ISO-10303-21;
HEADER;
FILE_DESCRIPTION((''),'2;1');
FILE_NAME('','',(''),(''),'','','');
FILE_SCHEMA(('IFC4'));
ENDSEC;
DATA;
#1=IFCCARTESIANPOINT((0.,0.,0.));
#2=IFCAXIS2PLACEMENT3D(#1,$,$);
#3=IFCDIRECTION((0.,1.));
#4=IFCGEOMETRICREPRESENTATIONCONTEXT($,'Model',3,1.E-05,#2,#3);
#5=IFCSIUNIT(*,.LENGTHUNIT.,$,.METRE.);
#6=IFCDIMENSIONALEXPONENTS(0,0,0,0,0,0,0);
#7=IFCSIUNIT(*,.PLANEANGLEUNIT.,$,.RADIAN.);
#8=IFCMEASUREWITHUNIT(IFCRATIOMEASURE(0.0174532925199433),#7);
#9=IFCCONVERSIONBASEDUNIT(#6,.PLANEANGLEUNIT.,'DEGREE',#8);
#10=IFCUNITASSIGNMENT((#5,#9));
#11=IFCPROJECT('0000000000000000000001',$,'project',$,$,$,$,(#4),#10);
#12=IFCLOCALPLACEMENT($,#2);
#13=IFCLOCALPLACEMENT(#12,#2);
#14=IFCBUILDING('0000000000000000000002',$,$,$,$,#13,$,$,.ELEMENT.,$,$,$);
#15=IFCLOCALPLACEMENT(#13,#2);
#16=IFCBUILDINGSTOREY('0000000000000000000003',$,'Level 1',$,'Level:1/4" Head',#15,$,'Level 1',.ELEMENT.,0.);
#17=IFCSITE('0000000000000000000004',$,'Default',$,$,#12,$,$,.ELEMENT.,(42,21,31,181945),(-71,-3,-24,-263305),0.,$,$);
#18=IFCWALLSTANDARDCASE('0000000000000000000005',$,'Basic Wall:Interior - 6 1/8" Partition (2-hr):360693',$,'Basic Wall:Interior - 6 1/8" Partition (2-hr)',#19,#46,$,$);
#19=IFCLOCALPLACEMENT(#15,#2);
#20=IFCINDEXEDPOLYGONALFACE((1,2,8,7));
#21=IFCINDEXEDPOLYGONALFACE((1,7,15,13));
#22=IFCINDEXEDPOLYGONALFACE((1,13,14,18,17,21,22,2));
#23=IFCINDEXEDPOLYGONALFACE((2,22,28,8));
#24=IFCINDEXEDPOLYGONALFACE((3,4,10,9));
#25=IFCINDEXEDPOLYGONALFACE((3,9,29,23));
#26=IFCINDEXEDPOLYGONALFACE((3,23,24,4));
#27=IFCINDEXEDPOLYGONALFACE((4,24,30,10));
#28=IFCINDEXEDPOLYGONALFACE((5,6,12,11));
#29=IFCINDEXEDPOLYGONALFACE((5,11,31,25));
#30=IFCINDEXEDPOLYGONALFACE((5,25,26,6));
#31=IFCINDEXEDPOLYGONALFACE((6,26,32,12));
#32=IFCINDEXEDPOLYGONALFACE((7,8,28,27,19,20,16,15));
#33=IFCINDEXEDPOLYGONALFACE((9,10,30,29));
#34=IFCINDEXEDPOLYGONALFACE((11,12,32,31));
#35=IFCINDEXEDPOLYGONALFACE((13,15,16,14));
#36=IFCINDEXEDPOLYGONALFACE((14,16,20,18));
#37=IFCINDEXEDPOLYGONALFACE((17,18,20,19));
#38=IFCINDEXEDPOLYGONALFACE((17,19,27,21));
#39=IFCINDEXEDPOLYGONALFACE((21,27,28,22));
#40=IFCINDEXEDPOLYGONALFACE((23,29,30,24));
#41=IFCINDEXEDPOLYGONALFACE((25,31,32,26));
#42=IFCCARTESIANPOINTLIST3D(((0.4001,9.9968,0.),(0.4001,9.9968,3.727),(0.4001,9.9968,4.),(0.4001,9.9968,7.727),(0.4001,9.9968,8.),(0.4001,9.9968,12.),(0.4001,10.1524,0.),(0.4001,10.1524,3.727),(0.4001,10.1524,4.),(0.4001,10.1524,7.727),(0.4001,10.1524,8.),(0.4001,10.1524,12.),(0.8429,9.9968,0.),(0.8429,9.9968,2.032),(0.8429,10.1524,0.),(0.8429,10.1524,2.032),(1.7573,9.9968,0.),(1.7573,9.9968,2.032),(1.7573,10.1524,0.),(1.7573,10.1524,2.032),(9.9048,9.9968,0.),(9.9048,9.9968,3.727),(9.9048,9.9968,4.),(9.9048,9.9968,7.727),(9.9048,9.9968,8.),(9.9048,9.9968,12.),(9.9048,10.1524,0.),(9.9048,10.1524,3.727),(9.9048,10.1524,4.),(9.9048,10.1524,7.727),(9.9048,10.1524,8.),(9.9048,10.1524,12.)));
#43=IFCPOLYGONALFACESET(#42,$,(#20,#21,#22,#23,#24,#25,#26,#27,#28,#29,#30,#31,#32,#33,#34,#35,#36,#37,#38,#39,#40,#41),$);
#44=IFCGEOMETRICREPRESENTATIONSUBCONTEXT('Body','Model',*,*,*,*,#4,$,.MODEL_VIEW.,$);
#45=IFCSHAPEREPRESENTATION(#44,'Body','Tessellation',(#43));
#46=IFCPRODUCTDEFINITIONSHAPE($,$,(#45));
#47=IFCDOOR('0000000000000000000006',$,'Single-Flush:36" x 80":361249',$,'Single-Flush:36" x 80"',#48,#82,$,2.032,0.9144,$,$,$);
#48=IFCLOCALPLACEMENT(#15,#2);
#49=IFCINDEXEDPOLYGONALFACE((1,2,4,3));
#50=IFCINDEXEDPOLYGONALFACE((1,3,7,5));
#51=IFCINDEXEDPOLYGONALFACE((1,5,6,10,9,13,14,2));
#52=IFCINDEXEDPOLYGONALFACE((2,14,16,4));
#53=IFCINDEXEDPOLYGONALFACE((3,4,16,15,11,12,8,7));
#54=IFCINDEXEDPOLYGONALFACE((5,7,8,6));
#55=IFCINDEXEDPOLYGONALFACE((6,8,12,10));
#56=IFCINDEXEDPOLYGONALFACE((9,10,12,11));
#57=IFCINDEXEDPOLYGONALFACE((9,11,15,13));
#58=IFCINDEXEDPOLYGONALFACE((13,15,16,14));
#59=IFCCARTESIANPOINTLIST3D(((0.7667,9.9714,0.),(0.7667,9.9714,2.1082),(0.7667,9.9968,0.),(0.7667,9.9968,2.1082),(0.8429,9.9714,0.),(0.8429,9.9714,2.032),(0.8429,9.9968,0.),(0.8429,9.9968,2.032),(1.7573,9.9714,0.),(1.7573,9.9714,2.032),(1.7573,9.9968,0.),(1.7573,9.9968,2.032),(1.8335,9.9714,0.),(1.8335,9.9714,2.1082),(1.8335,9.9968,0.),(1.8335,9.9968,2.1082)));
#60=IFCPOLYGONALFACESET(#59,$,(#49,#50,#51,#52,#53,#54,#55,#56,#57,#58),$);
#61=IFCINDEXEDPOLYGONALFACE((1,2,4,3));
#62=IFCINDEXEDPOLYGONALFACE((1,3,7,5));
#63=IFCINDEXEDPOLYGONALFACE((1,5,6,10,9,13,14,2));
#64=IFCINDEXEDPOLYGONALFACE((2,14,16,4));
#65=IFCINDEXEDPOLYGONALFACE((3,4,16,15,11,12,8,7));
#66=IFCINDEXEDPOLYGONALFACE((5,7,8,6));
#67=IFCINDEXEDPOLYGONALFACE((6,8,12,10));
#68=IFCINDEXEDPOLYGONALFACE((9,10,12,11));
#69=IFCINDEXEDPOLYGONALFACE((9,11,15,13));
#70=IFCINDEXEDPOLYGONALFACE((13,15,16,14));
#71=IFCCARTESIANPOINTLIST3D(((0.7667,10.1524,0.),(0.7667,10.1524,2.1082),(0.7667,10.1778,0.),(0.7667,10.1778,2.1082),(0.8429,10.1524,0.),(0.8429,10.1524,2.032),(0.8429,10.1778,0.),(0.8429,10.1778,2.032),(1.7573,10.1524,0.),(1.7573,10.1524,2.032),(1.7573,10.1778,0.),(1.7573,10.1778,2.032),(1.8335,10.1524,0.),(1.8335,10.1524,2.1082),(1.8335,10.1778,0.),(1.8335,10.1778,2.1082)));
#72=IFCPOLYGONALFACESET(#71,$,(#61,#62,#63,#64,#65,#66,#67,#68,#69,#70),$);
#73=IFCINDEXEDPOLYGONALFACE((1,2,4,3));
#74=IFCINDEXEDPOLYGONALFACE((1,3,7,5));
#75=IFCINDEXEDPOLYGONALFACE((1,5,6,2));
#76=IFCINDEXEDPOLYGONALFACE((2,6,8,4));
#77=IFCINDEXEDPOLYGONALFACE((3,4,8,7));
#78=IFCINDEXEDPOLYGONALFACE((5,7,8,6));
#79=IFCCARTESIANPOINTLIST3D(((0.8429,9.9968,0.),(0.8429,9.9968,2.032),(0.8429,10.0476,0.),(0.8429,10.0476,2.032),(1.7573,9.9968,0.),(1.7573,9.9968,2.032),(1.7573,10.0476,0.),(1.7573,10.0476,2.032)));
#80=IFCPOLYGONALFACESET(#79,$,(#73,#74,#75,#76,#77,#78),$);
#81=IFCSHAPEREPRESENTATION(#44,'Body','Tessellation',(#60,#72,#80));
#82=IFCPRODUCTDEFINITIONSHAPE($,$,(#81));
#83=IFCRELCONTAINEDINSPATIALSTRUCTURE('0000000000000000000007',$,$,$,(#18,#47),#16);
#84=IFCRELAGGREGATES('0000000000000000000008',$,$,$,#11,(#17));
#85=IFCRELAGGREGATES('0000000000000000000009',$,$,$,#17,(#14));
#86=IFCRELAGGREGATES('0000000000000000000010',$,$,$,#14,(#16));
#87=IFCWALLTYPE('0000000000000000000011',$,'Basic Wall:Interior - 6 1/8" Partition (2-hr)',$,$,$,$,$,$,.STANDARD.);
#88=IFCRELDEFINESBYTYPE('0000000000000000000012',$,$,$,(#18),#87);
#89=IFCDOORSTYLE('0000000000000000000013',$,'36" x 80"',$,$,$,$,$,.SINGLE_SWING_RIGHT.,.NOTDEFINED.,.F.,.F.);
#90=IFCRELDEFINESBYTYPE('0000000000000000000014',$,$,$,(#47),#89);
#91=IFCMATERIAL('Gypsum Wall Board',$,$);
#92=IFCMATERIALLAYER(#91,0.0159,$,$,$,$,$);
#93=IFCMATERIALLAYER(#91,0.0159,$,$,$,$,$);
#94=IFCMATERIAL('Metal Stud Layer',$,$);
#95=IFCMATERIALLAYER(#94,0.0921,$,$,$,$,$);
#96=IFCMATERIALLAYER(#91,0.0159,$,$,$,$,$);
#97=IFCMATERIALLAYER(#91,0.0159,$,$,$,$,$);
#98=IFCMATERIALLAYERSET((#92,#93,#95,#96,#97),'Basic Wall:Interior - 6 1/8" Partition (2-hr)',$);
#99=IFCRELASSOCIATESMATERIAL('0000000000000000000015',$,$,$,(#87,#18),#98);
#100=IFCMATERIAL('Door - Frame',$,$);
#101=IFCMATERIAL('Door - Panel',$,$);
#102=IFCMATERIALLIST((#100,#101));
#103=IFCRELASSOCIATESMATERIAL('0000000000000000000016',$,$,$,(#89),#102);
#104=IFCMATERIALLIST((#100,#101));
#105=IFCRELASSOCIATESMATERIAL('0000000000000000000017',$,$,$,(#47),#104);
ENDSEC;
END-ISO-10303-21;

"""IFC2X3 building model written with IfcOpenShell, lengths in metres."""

from ifc_helpers import new_model, entity, si_unit, converted_unit, direction, frame, frame_2d, origin, origin_2d_with_axis, place, context, subcontext, project, spatial, polyline, rectangle, outline, extrude, source, transform, mapped, material, material_list, layer, layer_set, layer_usage, type_object, type_shapes, element, fill, save


model = new_model("IFC2X3")

# Units and contexts
model_context = context("Model", 3, precision=1e-05, world=origin(), true_north=direction((0.0, 1.0)))
body_context = subcontext(model_context, "Body", "Model", "MODEL_VIEW")
ifc_project = project(units=[si_unit("LENGTHUNIT", "METRE"), converted_unit("PLANEANGLEUNIT", "DEGREE", entity("IfcRatioMeasure", 0.0174532925199433), si_unit("PLANEANGLEUNIT", "RADIAN"), dimensions=[0, 0, 0, 0, 0, 0, 0])], contexts=[model_context])

# Site, building, storey
site_placement = place(None, origin())
site = spatial("IfcSite", under=ifc_project, at=site_placement, Name="Default", CompositionType="ELEMENT", RefLatitude=(42, 21, 31, 181945), RefLongitude=(-71, -3, -24, -263305), RefElevation=0.0)
building_placement = place(site_placement, origin())
building = spatial("IfcBuilding", under=site, at=building_placement, CompositionType="ELEMENT")
storey_placement = place(building_placement, origin())
storey = spatial("IfcBuildingStorey", under=building, at=storey_placement, Name="Level 1", ObjectType="Level:1/4\" Head", LongName="Level 1", CompositionType="ELEMENT", Elevation=0.0)

# Wall, openings, door
ifc_material_1 = material(Name="Gypsum Wall Board")
ifc_layer_1 = layer(ifc_material_1, 0.0159)
ifc_layer_2 = layer(ifc_material_1, 0.0159)
ifc_material_2 = material(Name="Metal Stud Layer")
ifc_layer_3 = layer(ifc_material_2, 0.0921)
ifc_layer_4 = layer(ifc_material_1, 0.0159)
ifc_layer_5 = layer(ifc_material_1, 0.0159)
ifc_layer_set = layer_set([ifc_layer_1, ifc_layer_2, ifc_layer_3, ifc_layer_4, ifc_layer_5], Name="Basic Wall:Interior - 6 1/8\" Partition (2-hr)")
ifc_layer_usage = layer_usage(ifc_layer_set, "AXIS2", "POSITIVE", -0.0778)
wall_type = type_object("IfcWallType", Name="Basic Wall:Interior - 6 1/8\" Partition (2-hr)", PredefinedType="STANDARD", material=ifc_layer_set)
wall_placement = place(storey_placement, frame((9.9048, 10.0746, 0.0), z_axis=(0.0, 0.0, 1.0), x_axis=(-1.0, 0.0, 0.0)))
wall = element("IfcWallStandardCase", 1, at=wall_placement, inside=storey, type_object=wall_type, material=ifc_layer_usage, Name="Basic Wall:Interior - 6 1/8\" Partition (2-hr):360693", ObjectType="Basic Wall:Interior - 6 1/8\" Partition (2-hr)", context=body_context, shape_type="SweptSolid", body=[
    extrude(rectangle(XDim=9.5047, YDim=0.1556, at=frame_2d((4.7523, 0.0), x_axis=(-1.0, 0.0))), origin(), (0.0, 0.0, 1.0), 12.0),
])
opening_1_placement = place(storey_placement, frame((9.9048, 10.0746, 0.0), z_axis=(0.0, 0.0, 1.0), x_axis=(-1.0, 0.0, 0.0)))
element("IfcOpeningElement", 2, at=opening_1_placement, cuts=wall, ObjectType="Opening", context=body_context, shape_type="SweptSolid", body=[
    extrude(rectangle(XDim=9.5047, YDim=0.1556, at=origin_2d_with_axis()), frame((4.7523, 0.0, 7.727)), (0.0, 0.0, 1.0), 0.2731),
])
opening_2_placement = place(storey_placement, frame((9.9048, 10.0746, 0.0), z_axis=(0.0, 0.0, 1.0), x_axis=(-1.0, 0.0, 0.0)))
element("IfcOpeningElement", 3, at=opening_2_placement, cuts=wall, ObjectType="Opening", context=body_context, shape_type="SweptSolid", body=[
    extrude(rectangle(XDim=9.5047, YDim=0.1556, at=origin_2d_with_axis()), frame((4.7523, 0.0, 3.727)), (0.0, 0.0, 1.0), 0.2731),
])
opening_3_placement = place(wall_placement, frame((8.1475, -0.0778, 0.0)))
opening_3 = element("IfcOpeningElement", 4, at=opening_3_placement, cuts=wall, ObjectType="Opening", context=body_context, shape_type="SweptSolid", body=[
    extrude(rectangle(XDim=0.9144, YDim=2.032, at=frame_2d((1.016, 0.4572), x_axis=(0.0, 1.0))), frame((0.0, 0.0, 0.0), z_axis=(0.0, 1.0, 0.0), x_axis=(0.0, 0.0, 1.0)), (0.0, 0.0, 1.0), 0.1556),
])
ifc_material_3 = material(Name="Door - Frame")
ifc_material_4 = material(Name="Door - Panel")
ifc_material_list_1 = material_list([ifc_material_3, ifc_material_4])
ifc_material_list_2 = material_list([ifc_material_3, ifc_material_4])
door_style = type_object("IfcDoorStyle", Name="36\" x 80\"", ConstructionType="NOTDEFINED", OperationType="SINGLE_SWING_RIGHT", ParameterTakesPrecedence=False, Sizeable=False, material=ifc_material_list_2)
shared_shape = source(origin(), body_context, "Body", "SweptSolid", [
    extrude(outline(polyline([(-0.5334, -1.0732), (0.5334, -1.0732), (0.5334, 1.0351), (0.4572, 1.0351), (0.4572, -0.997), (-0.4572, -0.997), (-0.4572, 1.0351), (-0.5334, 1.0351), (-0.5334, -1.0732)])), frame((0.4572, 0.1556, 1.0351), z_axis=(0.0, 1.0, 0.0), x_axis=(1.0, 0.0, 0.0)), (0.0, 0.0, 1.0), 0.0254),
    extrude(outline(polyline([(-1.0732, -0.5334), (1.0351, -0.5334), (1.0351, -0.4572), (-0.997, -0.4572), (-0.997, 0.4572), (1.0351, 0.4572), (1.0351, 0.5334), (-1.0732, 0.5334), (-1.0732, -0.5334)])), frame((0.4572, -0.0254, 1.0351), z_axis=(0.0, 1.0, 0.0), x_axis=(0.0, 0.0, -1.0)), (0.0, 0.0, 1.0), 0.0254),
    extrude(rectangle(XDim=0.0508, YDim=0.9144, at=frame_2d((0.0, 0.0), x_axis=(1.0, 0.0))), frame((0.4572, 0.1302, 0.0), z_axis=(0.0, 0.0, 1.0), x_axis=(0.0, 1.0, 0.0)), (0.0, 0.0, 1.0), 2.032),
])
type_shapes(door_style, [shared_shape])
door_placement = place(opening_3_placement, origin())
door = element("IfcDoor", 5, at=door_placement, inside=storey, type_object=door_style, material=ifc_material_list_1, Name="Single-Flush:36\" x 80\":361249", ObjectType="Single-Flush:36\" x 80\"", OverallHeight=2.032, OverallWidth=0.9144, context=body_context, shape_type="MappedRepresentation", body=[
    mapped(shared_shape, transform((0.0, 0.0, 0.0), scale=1.0)),
])
fill(opening_3, door)

save(model, "model.ifc")
